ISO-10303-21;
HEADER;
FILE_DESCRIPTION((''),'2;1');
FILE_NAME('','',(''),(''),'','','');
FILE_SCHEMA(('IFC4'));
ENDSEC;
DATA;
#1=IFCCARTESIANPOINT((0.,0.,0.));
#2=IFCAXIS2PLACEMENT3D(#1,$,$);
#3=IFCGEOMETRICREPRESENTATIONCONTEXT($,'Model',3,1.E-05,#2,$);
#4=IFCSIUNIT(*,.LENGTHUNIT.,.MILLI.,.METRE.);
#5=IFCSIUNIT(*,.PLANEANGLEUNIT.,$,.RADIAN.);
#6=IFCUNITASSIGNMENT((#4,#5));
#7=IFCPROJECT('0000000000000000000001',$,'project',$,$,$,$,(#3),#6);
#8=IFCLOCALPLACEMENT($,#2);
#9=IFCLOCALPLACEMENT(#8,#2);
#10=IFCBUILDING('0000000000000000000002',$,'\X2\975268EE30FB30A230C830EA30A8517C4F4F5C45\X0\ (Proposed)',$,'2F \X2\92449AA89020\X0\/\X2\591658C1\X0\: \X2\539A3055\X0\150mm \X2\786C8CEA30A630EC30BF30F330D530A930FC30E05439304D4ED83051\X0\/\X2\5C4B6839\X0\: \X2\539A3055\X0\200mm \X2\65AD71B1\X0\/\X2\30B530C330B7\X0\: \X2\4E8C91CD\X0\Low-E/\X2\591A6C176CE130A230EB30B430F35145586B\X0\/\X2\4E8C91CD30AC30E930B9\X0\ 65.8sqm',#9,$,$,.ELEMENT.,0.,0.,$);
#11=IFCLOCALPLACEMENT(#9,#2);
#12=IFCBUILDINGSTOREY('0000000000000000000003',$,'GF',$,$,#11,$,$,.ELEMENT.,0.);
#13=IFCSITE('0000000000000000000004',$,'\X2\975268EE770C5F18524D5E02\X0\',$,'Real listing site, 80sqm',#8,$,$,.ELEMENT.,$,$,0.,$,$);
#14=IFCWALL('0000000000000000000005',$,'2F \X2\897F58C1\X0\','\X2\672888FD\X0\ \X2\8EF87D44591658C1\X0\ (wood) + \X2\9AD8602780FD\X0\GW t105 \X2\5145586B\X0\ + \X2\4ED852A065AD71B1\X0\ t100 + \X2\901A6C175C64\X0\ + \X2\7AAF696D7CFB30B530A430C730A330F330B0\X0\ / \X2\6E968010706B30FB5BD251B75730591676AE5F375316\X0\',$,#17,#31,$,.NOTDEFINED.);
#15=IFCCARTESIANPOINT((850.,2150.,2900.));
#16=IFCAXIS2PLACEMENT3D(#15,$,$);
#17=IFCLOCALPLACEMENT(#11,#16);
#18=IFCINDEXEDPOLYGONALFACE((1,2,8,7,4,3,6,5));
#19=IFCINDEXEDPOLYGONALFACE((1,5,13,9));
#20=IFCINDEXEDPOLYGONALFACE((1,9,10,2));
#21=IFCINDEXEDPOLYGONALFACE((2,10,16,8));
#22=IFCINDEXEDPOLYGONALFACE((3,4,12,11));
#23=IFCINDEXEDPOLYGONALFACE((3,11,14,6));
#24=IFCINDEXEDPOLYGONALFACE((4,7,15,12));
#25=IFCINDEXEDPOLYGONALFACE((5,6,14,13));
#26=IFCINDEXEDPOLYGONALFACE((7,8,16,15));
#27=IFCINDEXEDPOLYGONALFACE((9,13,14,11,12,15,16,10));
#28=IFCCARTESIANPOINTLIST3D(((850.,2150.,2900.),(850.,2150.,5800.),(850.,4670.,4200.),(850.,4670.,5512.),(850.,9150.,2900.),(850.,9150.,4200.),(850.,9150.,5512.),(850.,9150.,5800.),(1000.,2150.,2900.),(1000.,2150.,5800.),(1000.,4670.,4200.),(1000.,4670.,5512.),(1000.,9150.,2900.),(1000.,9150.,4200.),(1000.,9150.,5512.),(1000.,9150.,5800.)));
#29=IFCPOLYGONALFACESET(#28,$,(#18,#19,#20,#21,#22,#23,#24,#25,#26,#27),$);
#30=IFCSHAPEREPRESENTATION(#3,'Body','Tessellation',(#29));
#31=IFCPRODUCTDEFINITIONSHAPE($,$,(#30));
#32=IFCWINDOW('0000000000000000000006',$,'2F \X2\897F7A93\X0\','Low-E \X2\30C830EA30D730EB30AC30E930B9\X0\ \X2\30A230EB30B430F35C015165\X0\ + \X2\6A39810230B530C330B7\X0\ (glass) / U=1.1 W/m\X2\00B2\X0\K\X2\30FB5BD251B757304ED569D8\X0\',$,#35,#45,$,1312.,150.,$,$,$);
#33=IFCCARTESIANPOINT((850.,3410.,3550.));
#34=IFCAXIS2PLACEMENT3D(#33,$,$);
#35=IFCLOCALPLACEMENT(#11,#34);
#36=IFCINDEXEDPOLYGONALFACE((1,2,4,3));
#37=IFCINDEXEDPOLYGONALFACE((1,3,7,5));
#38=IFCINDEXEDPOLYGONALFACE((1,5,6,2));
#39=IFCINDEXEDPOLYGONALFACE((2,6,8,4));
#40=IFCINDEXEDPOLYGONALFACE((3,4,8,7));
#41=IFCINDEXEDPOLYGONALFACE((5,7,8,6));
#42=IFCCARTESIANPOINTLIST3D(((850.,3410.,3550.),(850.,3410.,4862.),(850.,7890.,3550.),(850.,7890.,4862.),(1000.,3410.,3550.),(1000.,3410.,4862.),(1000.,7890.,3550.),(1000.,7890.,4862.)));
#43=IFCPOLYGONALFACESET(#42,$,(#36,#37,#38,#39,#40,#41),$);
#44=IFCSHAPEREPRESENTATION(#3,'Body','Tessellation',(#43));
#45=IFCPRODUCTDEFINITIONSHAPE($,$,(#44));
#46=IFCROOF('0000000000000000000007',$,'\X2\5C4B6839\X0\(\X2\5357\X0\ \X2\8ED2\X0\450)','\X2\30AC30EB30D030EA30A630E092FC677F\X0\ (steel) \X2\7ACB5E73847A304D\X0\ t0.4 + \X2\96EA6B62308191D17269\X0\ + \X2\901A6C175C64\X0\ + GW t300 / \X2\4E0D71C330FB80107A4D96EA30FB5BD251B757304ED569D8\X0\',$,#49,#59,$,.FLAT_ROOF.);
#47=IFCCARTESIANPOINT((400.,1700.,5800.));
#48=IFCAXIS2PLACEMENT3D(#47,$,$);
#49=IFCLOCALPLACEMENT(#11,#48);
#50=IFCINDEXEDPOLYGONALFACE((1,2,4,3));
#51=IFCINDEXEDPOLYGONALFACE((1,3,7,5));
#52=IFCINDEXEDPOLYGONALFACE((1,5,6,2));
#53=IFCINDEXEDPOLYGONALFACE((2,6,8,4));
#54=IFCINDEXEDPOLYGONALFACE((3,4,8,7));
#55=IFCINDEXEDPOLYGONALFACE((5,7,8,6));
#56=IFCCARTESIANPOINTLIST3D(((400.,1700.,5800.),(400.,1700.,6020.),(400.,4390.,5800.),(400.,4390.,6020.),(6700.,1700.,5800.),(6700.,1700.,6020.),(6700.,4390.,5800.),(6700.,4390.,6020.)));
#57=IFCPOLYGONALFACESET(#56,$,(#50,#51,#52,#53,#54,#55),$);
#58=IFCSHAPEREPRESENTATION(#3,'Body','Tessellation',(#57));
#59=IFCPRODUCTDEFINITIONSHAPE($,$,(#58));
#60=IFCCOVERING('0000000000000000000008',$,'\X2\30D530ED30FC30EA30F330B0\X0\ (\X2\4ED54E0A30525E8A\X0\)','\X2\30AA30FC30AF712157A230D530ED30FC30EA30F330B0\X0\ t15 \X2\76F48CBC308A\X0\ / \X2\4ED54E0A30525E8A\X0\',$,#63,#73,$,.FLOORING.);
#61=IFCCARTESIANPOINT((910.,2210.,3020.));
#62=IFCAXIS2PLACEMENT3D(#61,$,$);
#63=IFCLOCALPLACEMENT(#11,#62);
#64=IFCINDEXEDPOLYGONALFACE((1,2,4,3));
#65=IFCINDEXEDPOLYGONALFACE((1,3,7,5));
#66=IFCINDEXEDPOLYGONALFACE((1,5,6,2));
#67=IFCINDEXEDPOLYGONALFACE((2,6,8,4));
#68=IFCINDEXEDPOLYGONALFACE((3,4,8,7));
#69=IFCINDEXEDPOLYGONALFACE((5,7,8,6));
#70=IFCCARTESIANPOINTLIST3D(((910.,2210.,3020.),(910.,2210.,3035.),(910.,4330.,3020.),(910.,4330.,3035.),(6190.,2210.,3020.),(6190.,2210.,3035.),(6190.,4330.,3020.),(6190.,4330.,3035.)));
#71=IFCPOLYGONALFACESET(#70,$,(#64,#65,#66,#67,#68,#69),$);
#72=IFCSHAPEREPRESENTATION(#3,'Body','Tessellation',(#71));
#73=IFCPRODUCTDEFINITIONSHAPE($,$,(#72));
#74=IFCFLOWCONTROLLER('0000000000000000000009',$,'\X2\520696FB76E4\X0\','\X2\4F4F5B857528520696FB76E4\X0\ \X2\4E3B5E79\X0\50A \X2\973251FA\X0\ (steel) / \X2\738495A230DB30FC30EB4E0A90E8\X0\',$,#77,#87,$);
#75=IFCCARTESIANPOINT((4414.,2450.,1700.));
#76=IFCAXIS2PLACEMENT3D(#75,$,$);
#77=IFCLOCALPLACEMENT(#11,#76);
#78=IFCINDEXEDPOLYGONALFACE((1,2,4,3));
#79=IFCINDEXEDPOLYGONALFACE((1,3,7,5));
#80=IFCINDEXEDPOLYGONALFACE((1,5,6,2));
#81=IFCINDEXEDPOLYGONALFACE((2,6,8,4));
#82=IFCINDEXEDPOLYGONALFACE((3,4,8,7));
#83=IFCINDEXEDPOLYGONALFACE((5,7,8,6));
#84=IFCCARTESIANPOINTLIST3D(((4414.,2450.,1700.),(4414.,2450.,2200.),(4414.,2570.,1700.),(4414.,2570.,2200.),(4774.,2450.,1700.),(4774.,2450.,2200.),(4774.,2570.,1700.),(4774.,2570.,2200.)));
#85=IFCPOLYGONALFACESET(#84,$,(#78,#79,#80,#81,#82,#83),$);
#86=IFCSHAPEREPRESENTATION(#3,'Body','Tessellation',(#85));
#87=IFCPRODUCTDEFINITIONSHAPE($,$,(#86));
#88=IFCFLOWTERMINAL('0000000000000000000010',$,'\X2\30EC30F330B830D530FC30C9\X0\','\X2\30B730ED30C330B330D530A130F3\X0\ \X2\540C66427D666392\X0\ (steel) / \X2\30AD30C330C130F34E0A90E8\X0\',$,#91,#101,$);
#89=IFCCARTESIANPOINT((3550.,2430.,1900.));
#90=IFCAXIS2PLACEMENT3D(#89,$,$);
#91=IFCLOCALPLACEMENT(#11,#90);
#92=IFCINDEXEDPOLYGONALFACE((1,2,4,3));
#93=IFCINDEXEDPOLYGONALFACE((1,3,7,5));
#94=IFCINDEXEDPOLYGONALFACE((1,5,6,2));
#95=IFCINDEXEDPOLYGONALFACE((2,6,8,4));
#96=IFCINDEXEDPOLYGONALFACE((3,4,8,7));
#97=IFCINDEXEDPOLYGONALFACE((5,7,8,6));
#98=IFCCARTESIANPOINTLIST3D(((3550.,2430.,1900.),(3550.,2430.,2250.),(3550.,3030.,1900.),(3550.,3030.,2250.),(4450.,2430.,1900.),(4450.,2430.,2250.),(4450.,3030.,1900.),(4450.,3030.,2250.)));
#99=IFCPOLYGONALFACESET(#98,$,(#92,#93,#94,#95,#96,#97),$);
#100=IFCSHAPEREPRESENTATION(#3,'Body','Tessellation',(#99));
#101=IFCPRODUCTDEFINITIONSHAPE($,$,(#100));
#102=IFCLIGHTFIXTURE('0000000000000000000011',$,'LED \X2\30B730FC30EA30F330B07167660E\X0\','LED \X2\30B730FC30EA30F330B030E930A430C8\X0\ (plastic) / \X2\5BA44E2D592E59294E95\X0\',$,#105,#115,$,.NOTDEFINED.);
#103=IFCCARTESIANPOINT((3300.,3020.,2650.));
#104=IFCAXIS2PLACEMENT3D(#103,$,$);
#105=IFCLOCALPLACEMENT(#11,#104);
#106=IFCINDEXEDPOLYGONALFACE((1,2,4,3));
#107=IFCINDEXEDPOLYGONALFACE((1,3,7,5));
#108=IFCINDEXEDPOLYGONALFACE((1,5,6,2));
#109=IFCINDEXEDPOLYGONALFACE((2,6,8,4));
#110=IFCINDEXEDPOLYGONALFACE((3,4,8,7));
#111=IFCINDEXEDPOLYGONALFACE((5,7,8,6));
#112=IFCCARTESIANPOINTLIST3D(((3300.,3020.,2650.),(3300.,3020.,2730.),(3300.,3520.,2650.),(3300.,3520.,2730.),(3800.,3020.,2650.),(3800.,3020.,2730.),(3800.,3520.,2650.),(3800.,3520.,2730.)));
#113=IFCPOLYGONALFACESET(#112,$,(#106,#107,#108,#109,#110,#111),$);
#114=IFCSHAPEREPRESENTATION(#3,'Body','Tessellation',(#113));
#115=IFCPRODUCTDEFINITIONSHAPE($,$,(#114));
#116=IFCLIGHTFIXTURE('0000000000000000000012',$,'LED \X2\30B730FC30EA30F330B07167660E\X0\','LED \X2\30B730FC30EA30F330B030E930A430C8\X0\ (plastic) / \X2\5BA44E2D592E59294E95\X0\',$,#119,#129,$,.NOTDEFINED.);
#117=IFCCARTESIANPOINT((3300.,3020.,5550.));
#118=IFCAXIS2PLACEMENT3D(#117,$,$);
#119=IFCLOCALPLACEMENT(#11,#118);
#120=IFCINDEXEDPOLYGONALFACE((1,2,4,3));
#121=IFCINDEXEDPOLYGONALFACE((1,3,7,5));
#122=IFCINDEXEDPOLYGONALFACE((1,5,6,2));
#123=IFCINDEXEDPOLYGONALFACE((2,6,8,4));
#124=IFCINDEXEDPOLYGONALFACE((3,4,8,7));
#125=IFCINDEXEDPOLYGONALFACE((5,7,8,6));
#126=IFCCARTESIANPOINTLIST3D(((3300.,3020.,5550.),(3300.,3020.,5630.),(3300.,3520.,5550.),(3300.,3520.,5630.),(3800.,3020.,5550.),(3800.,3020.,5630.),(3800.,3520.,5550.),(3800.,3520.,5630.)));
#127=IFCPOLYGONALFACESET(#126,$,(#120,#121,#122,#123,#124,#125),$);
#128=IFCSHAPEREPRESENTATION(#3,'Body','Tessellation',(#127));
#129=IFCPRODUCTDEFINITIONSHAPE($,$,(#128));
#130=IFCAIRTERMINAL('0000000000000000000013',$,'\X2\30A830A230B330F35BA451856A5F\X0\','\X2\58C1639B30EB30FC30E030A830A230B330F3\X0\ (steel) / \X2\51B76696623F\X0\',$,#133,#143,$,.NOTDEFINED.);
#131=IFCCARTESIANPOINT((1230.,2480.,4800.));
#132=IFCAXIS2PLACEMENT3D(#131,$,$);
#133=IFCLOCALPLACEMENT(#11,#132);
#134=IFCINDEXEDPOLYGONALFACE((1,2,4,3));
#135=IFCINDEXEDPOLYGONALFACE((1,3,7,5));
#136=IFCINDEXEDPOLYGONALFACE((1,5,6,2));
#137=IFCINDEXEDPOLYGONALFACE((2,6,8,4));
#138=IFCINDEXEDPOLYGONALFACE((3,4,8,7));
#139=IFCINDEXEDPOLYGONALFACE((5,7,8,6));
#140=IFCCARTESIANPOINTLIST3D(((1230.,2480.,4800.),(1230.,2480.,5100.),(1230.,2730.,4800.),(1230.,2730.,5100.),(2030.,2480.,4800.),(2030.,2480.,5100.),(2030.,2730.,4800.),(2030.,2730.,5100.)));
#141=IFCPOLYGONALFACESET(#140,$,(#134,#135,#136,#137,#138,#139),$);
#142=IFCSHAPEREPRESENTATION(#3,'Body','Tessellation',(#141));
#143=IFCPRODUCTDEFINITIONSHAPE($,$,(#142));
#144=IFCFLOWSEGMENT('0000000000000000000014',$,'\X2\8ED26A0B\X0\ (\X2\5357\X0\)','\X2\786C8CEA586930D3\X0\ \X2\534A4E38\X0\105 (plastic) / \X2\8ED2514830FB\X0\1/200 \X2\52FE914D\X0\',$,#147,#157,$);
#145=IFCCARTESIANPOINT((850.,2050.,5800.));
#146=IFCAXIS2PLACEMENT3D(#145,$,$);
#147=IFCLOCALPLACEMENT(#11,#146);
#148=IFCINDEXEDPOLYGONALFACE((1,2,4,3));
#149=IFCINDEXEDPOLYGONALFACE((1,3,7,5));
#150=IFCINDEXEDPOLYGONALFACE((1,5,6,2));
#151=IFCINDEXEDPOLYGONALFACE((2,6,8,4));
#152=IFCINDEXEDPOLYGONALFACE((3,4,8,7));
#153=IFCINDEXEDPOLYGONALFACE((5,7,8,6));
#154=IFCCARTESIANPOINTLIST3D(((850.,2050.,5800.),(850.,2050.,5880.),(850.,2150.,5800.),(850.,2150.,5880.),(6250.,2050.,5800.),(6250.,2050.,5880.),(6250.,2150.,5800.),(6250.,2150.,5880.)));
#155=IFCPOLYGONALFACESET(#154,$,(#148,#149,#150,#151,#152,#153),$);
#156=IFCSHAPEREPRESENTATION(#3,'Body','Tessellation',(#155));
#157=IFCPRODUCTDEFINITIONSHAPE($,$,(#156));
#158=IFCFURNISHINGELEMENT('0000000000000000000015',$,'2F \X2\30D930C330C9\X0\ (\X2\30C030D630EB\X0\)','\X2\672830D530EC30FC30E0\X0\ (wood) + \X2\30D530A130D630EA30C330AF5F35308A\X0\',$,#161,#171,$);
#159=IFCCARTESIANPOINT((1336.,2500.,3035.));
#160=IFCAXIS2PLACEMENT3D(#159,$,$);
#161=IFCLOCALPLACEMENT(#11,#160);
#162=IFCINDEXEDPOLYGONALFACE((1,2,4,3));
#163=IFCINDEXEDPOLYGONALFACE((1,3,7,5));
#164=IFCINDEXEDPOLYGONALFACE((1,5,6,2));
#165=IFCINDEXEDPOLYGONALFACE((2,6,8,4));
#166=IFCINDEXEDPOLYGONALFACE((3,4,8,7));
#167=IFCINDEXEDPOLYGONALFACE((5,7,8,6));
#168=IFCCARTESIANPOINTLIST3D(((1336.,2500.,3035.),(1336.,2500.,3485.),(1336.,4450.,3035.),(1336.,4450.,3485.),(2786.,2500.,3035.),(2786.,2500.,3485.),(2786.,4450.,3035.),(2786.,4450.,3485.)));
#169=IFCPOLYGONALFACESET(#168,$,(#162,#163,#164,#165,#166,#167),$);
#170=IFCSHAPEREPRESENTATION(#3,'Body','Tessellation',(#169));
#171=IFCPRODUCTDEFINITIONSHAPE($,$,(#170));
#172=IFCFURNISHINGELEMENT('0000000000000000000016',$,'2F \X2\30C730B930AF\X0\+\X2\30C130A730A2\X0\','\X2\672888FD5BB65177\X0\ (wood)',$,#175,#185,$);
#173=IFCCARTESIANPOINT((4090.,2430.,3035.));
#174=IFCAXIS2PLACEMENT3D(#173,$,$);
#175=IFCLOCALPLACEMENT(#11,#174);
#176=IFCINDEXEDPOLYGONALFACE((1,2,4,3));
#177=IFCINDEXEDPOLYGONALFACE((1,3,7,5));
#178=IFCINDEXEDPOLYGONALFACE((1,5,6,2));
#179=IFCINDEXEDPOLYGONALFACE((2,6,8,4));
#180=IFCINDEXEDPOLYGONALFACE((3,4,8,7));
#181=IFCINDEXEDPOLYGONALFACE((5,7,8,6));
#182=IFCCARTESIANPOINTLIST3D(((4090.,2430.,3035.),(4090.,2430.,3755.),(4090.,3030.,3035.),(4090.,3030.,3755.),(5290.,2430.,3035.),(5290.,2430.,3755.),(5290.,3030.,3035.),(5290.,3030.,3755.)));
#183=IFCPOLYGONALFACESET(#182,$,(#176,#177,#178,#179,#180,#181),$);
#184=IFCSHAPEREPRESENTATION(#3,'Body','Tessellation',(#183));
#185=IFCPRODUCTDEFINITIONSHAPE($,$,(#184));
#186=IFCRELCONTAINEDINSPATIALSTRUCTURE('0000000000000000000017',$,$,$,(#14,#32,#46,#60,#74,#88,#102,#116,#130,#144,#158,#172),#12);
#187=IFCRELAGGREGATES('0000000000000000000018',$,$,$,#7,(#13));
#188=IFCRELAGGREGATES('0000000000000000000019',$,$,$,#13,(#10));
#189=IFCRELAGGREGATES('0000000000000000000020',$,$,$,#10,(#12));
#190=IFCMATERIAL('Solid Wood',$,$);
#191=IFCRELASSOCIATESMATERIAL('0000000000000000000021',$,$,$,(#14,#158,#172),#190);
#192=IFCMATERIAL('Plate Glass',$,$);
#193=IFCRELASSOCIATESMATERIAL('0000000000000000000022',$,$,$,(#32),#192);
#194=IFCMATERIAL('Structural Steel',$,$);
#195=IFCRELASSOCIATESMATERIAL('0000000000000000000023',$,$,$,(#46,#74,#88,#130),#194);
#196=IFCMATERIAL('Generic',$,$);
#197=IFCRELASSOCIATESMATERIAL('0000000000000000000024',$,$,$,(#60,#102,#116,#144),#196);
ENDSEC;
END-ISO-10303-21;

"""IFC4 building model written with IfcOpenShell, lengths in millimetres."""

from ifc_helpers import new_model, si_unit, frame, frame_2d, origin, place, context, project, spatial, rectangle, extrude, material, element, fill, save


model = new_model("IFC4")

# Units and contexts
model_context = context("Model", 3, precision=1e-05, world=origin())
ifc_project = project(units=[si_unit("LENGTHUNIT", "METRE", prefix="MILLI"), si_unit("PLANEANGLEUNIT", "RADIAN")], contexts=[model_context])

# Site, building, storey
site_placement = place(None, origin())
site = spatial("IfcSite", under=ifc_project, at=site_placement, Name="青森県弘前市", ObjectType="Real listing site, 80sqm", CompositionType="ELEMENT", RefElevation=0.0)
building_placement = place(site_placement, origin())
building = spatial("IfcBuilding", under=site, at=building_placement, Name="青森・アトリエ兼住居 (Proposed)", ObjectType="2F 鉄骨造/外壁: 厚さ150mm 硬質ウレタンフォーム吹き付け/屋根: 厚さ200mm 断熱/サッシ: 二重Low-E/多気泡アルゴン充填/二重ガラス 65.8sqm", CompositionType="ELEMENT", ElevationOfRefHeight=0.0, ElevationOfTerrain=0.0)
storey_placement = place(building_placement, origin())
storey = spatial("IfcBuildingStorey", under=building, at=storey_placement, Name="GF", CompositionType="ELEMENT", Elevation=0.0)

# Shared definitions
ifc_material_1 = material(Name="Solid Wood")

# Wall, opening, window
ifc_material_2 = material(Name="Plate Glass")
wall_1_placement = place(storey_placement, frame((850.0, 2150.0, 2900.0)))
wall_1 = element("IfcWall", 1, at=wall_1_placement, inside=storey, material=ifc_material_1, Name="2F 西壁", Description="木製 軸組外壁 (wood) + 高性能GW t105 充填 + 付加断熱 t100 + 通気層 + 窯業系サイディング / 準耐火・寒冷地外皮強化", PredefinedType="NOTDEFINED", context=model_context, shape_type="SweptSolid", body=[
    extrude(rectangle(XDim=150.0, YDim=7000.0, at=frame_2d((75.0, 3500.0))), frame((850.0, 2150.0, 2900.0)), (0.0, 0.0, 1.0), 2900.0),
])
opening_1_placement = place(storey_placement, frame((850.0, 3410.0, 3550.0)))
opening_1 = element("IfcOpeningElement", 2, at=opening_1_placement, cuts=wall_1, PredefinedType="NOTDEFINED", context=model_context, shape_type="SweptSolid", body=[
    extrude(rectangle(XDim=150.0, YDim=4480.0, at=frame_2d((75.0, 2240.0))), frame((850.0, 3410.0, 3550.0)), (0.0, 0.0, 1.0), 1312.0),
])
window_1_placement = place(storey_placement, frame((850.0, 3410.0, 3550.0)))
window_1 = element("IfcWindow", 3, at=window_1_placement, inside=storey, material=ifc_material_2, Name="2F 西窓", Description="Low-E トリプルガラス アルゴン封入 + 樹脂サッシ (glass) / U=1.1 W/m²K・寒冷地仕様", OverallHeight=1312.0, OverallWidth=150.0, context=model_context, shape_type="SweptSolid", body=[
    extrude(rectangle(XDim=150.0, YDim=4480.0, at=frame_2d((75.0, 2240.0))), frame((850.0, 3410.0, 3550.0)), (0.0, 0.0, 1.0), 1312.0),
])
fill(opening_1, window_1)

# Roof
ifc_material_3 = material(Name="Structural Steel")
for number, where, name in (
    (4, (400.0, 1700.0, 5800.0), "屋根(南 軒450)"),
):
    element("IfcRoof", number, at=place(storey_placement, frame(where)), inside=storey, material=ifc_material_3, Name=name, Description="ガルバリウム鋼板 (steel) 立平葺き t0.4 + 雪止め金物 + 通気層 + GW t300 / 不燃・耐積雪・寒冷地仕様", PredefinedType="FLAT_ROOF", context=model_context, shape_type="SweptSolid", body=[
        extrude(rectangle(XDim=6300.0, YDim=2690.0, at=frame_2d((3150.0, 1345.0))), frame((400.0, 1700.0, 5800.0)), (0.0, 0.0, 1.0), 220.0),
    ])

# Covering
ifc_material_4 = material(Name="Generic")
covering_placement = place(storey_placement, frame((910.0, 2210.0, 3020.0)))
element("IfcCovering", 5, at=covering_placement, inside=storey, material=ifc_material_4, Name="フローリング (仕上げ床)", Description="オーク無垢フローリング t15 直貼り / 仕上げ床", PredefinedType="FLOORING", context=model_context, shape_type="SweptSolid", body=[
    extrude(rectangle(XDim=5280.0, YDim=2120.0, at=frame_2d((2640.0, 1060.0))), frame((910.0, 2210.0, 3020.0)), (0.0, 0.0, 1.0), 15.0),
])

# Flow controller
flow_controller_placement = place(storey_placement, frame((4414.0, 2450.0, 1700.0)))
element("IfcFlowController", 6, at=flow_controller_placement, inside=storey, material=ifc_material_3, Name="分電盤", Description="住宅用分電盤 主幹50A 露出 (steel) / 玄関ホール上部", context=model_context, shape_type="SweptSolid", body=[
    extrude(rectangle(XDim=360.0, YDim=120.0, at=frame_2d((180.0, 60.0))), frame((4414.0, 2450.0, 1700.0)), (0.0, 0.0, 1.0), 500.0),
])

# Flow terminal
flow_terminal_placement = place(storey_placement, frame((3550.0, 2430.0, 1900.0)))
element("IfcFlowTerminal", 7, at=flow_terminal_placement, inside=storey, material=ifc_material_3, Name="レンジフード", Description="シロッコファン 同時給排 (steel) / キッチン上部", context=model_context, shape_type="SweptSolid", body=[
    extrude(rectangle(XDim=900.0, YDim=600.0, at=frame_2d((450.0, 300.0))), frame((3550.0, 2430.0, 1900.0)), (0.0, 0.0, 1.0), 350.0),
])

# Light fixtures
light_fixture_1_placement = place(storey_placement, frame((3300.0, 3020.0, 2650.0)))
element("IfcLightFixture", 8, at=light_fixture_1_placement, inside=storey, material=ifc_material_4, Name="LED シーリング照明", Description="LED シーリングライト (plastic) / 室中央天井", PredefinedType="NOTDEFINED", context=model_context, shape_type="SweptSolid", body=[
    extrude(rectangle(XDim=500.0, YDim=500.0, at=frame_2d((250.0, 250.0))), frame((3300.0, 3020.0, 2650.0)), (0.0, 0.0, 1.0), 80.0),
])
light_fixture_2_placement = place(storey_placement, frame((3300.0, 3020.0, 5550.0)))
element("IfcLightFixture", 9, at=light_fixture_2_placement, inside=storey, material=ifc_material_4, Name="LED シーリング照明", Description="LED シーリングライト (plastic) / 室中央天井", PredefinedType="NOTDEFINED", context=model_context, shape_type="SweptSolid", body=[
    extrude(rectangle(XDim=500.0, YDim=500.0, at=frame_2d((250.0, 250.0))), frame((3300.0, 3020.0, 5550.0)), (0.0, 0.0, 1.0), 80.0),
])

# Air terminal
air_terminal_placement = place(storey_placement, frame((1230.0, 2480.0, 4800.0)))
element("IfcAirTerminal", 10, at=air_terminal_placement, inside=storey, material=ifc_material_3, Name="エアコン室内機", Description="壁掛ルームエアコン (steel) / 冷暖房", PredefinedType="NOTDEFINED", context=model_context, shape_type="SweptSolid", body=[
    extrude(rectangle(XDim=800.0, YDim=250.0, at=frame_2d((400.0, 125.0))), frame((1230.0, 2480.0, 4800.0)), (0.0, 0.0, 1.0), 300.0),
])

# Flow segment
flow_segment_placement = place(storey_placement, frame((850.0, 2050.0, 5800.0)))
element("IfcFlowSegment", 11, at=flow_segment_placement, inside=storey, material=ifc_material_4, Name="軒樋 (南)", Description="硬質塩ビ 半丸105 (plastic) / 軒先・1/200 勾配", context=model_context, shape_type="SweptSolid", body=[
    extrude(rectangle(XDim=5400.0, YDim=100.0, at=frame_2d((2700.0, 50.0))), frame((850.0, 2050.0, 5800.0)), (0.0, 0.0, 1.0), 80.0),
])

# Furnishing elements
furnishing_1_placement = place(storey_placement, frame((1336.0, 2500.0, 3035.0)))
element("IfcFurnishingElement", 12, at=furnishing_1_placement, inside=storey, material=ifc_material_1, Name="2F ベッド (ダブル)", Description="木フレーム (wood) + ファブリック張り", context=model_context, shape_type="SweptSolid", body=[
    extrude(rectangle(XDim=1450.0, YDim=1950.0, at=frame_2d((725.0, 975.0))), frame((1336.0, 2500.0, 3035.0)), (0.0, 0.0, 1.0), 450.0),
])
furnishing_2_placement = place(storey_placement, frame((4090.0, 2430.0, 3035.0)))
element("IfcFurnishingElement", 13, at=furnishing_2_placement, inside=storey, material=ifc_material_1, Name="2F デスク+チェア", Description="木製家具 (wood)", context=model_context, shape_type="SweptSolid", body=[
    extrude(rectangle(XDim=1200.0, YDim=600.0, at=frame_2d((600.0, 300.0))), frame((4090.0, 2430.0, 3035.0)), (0.0, 0.0, 1.0), 720.0),
])

save(model, "model.ifc")
